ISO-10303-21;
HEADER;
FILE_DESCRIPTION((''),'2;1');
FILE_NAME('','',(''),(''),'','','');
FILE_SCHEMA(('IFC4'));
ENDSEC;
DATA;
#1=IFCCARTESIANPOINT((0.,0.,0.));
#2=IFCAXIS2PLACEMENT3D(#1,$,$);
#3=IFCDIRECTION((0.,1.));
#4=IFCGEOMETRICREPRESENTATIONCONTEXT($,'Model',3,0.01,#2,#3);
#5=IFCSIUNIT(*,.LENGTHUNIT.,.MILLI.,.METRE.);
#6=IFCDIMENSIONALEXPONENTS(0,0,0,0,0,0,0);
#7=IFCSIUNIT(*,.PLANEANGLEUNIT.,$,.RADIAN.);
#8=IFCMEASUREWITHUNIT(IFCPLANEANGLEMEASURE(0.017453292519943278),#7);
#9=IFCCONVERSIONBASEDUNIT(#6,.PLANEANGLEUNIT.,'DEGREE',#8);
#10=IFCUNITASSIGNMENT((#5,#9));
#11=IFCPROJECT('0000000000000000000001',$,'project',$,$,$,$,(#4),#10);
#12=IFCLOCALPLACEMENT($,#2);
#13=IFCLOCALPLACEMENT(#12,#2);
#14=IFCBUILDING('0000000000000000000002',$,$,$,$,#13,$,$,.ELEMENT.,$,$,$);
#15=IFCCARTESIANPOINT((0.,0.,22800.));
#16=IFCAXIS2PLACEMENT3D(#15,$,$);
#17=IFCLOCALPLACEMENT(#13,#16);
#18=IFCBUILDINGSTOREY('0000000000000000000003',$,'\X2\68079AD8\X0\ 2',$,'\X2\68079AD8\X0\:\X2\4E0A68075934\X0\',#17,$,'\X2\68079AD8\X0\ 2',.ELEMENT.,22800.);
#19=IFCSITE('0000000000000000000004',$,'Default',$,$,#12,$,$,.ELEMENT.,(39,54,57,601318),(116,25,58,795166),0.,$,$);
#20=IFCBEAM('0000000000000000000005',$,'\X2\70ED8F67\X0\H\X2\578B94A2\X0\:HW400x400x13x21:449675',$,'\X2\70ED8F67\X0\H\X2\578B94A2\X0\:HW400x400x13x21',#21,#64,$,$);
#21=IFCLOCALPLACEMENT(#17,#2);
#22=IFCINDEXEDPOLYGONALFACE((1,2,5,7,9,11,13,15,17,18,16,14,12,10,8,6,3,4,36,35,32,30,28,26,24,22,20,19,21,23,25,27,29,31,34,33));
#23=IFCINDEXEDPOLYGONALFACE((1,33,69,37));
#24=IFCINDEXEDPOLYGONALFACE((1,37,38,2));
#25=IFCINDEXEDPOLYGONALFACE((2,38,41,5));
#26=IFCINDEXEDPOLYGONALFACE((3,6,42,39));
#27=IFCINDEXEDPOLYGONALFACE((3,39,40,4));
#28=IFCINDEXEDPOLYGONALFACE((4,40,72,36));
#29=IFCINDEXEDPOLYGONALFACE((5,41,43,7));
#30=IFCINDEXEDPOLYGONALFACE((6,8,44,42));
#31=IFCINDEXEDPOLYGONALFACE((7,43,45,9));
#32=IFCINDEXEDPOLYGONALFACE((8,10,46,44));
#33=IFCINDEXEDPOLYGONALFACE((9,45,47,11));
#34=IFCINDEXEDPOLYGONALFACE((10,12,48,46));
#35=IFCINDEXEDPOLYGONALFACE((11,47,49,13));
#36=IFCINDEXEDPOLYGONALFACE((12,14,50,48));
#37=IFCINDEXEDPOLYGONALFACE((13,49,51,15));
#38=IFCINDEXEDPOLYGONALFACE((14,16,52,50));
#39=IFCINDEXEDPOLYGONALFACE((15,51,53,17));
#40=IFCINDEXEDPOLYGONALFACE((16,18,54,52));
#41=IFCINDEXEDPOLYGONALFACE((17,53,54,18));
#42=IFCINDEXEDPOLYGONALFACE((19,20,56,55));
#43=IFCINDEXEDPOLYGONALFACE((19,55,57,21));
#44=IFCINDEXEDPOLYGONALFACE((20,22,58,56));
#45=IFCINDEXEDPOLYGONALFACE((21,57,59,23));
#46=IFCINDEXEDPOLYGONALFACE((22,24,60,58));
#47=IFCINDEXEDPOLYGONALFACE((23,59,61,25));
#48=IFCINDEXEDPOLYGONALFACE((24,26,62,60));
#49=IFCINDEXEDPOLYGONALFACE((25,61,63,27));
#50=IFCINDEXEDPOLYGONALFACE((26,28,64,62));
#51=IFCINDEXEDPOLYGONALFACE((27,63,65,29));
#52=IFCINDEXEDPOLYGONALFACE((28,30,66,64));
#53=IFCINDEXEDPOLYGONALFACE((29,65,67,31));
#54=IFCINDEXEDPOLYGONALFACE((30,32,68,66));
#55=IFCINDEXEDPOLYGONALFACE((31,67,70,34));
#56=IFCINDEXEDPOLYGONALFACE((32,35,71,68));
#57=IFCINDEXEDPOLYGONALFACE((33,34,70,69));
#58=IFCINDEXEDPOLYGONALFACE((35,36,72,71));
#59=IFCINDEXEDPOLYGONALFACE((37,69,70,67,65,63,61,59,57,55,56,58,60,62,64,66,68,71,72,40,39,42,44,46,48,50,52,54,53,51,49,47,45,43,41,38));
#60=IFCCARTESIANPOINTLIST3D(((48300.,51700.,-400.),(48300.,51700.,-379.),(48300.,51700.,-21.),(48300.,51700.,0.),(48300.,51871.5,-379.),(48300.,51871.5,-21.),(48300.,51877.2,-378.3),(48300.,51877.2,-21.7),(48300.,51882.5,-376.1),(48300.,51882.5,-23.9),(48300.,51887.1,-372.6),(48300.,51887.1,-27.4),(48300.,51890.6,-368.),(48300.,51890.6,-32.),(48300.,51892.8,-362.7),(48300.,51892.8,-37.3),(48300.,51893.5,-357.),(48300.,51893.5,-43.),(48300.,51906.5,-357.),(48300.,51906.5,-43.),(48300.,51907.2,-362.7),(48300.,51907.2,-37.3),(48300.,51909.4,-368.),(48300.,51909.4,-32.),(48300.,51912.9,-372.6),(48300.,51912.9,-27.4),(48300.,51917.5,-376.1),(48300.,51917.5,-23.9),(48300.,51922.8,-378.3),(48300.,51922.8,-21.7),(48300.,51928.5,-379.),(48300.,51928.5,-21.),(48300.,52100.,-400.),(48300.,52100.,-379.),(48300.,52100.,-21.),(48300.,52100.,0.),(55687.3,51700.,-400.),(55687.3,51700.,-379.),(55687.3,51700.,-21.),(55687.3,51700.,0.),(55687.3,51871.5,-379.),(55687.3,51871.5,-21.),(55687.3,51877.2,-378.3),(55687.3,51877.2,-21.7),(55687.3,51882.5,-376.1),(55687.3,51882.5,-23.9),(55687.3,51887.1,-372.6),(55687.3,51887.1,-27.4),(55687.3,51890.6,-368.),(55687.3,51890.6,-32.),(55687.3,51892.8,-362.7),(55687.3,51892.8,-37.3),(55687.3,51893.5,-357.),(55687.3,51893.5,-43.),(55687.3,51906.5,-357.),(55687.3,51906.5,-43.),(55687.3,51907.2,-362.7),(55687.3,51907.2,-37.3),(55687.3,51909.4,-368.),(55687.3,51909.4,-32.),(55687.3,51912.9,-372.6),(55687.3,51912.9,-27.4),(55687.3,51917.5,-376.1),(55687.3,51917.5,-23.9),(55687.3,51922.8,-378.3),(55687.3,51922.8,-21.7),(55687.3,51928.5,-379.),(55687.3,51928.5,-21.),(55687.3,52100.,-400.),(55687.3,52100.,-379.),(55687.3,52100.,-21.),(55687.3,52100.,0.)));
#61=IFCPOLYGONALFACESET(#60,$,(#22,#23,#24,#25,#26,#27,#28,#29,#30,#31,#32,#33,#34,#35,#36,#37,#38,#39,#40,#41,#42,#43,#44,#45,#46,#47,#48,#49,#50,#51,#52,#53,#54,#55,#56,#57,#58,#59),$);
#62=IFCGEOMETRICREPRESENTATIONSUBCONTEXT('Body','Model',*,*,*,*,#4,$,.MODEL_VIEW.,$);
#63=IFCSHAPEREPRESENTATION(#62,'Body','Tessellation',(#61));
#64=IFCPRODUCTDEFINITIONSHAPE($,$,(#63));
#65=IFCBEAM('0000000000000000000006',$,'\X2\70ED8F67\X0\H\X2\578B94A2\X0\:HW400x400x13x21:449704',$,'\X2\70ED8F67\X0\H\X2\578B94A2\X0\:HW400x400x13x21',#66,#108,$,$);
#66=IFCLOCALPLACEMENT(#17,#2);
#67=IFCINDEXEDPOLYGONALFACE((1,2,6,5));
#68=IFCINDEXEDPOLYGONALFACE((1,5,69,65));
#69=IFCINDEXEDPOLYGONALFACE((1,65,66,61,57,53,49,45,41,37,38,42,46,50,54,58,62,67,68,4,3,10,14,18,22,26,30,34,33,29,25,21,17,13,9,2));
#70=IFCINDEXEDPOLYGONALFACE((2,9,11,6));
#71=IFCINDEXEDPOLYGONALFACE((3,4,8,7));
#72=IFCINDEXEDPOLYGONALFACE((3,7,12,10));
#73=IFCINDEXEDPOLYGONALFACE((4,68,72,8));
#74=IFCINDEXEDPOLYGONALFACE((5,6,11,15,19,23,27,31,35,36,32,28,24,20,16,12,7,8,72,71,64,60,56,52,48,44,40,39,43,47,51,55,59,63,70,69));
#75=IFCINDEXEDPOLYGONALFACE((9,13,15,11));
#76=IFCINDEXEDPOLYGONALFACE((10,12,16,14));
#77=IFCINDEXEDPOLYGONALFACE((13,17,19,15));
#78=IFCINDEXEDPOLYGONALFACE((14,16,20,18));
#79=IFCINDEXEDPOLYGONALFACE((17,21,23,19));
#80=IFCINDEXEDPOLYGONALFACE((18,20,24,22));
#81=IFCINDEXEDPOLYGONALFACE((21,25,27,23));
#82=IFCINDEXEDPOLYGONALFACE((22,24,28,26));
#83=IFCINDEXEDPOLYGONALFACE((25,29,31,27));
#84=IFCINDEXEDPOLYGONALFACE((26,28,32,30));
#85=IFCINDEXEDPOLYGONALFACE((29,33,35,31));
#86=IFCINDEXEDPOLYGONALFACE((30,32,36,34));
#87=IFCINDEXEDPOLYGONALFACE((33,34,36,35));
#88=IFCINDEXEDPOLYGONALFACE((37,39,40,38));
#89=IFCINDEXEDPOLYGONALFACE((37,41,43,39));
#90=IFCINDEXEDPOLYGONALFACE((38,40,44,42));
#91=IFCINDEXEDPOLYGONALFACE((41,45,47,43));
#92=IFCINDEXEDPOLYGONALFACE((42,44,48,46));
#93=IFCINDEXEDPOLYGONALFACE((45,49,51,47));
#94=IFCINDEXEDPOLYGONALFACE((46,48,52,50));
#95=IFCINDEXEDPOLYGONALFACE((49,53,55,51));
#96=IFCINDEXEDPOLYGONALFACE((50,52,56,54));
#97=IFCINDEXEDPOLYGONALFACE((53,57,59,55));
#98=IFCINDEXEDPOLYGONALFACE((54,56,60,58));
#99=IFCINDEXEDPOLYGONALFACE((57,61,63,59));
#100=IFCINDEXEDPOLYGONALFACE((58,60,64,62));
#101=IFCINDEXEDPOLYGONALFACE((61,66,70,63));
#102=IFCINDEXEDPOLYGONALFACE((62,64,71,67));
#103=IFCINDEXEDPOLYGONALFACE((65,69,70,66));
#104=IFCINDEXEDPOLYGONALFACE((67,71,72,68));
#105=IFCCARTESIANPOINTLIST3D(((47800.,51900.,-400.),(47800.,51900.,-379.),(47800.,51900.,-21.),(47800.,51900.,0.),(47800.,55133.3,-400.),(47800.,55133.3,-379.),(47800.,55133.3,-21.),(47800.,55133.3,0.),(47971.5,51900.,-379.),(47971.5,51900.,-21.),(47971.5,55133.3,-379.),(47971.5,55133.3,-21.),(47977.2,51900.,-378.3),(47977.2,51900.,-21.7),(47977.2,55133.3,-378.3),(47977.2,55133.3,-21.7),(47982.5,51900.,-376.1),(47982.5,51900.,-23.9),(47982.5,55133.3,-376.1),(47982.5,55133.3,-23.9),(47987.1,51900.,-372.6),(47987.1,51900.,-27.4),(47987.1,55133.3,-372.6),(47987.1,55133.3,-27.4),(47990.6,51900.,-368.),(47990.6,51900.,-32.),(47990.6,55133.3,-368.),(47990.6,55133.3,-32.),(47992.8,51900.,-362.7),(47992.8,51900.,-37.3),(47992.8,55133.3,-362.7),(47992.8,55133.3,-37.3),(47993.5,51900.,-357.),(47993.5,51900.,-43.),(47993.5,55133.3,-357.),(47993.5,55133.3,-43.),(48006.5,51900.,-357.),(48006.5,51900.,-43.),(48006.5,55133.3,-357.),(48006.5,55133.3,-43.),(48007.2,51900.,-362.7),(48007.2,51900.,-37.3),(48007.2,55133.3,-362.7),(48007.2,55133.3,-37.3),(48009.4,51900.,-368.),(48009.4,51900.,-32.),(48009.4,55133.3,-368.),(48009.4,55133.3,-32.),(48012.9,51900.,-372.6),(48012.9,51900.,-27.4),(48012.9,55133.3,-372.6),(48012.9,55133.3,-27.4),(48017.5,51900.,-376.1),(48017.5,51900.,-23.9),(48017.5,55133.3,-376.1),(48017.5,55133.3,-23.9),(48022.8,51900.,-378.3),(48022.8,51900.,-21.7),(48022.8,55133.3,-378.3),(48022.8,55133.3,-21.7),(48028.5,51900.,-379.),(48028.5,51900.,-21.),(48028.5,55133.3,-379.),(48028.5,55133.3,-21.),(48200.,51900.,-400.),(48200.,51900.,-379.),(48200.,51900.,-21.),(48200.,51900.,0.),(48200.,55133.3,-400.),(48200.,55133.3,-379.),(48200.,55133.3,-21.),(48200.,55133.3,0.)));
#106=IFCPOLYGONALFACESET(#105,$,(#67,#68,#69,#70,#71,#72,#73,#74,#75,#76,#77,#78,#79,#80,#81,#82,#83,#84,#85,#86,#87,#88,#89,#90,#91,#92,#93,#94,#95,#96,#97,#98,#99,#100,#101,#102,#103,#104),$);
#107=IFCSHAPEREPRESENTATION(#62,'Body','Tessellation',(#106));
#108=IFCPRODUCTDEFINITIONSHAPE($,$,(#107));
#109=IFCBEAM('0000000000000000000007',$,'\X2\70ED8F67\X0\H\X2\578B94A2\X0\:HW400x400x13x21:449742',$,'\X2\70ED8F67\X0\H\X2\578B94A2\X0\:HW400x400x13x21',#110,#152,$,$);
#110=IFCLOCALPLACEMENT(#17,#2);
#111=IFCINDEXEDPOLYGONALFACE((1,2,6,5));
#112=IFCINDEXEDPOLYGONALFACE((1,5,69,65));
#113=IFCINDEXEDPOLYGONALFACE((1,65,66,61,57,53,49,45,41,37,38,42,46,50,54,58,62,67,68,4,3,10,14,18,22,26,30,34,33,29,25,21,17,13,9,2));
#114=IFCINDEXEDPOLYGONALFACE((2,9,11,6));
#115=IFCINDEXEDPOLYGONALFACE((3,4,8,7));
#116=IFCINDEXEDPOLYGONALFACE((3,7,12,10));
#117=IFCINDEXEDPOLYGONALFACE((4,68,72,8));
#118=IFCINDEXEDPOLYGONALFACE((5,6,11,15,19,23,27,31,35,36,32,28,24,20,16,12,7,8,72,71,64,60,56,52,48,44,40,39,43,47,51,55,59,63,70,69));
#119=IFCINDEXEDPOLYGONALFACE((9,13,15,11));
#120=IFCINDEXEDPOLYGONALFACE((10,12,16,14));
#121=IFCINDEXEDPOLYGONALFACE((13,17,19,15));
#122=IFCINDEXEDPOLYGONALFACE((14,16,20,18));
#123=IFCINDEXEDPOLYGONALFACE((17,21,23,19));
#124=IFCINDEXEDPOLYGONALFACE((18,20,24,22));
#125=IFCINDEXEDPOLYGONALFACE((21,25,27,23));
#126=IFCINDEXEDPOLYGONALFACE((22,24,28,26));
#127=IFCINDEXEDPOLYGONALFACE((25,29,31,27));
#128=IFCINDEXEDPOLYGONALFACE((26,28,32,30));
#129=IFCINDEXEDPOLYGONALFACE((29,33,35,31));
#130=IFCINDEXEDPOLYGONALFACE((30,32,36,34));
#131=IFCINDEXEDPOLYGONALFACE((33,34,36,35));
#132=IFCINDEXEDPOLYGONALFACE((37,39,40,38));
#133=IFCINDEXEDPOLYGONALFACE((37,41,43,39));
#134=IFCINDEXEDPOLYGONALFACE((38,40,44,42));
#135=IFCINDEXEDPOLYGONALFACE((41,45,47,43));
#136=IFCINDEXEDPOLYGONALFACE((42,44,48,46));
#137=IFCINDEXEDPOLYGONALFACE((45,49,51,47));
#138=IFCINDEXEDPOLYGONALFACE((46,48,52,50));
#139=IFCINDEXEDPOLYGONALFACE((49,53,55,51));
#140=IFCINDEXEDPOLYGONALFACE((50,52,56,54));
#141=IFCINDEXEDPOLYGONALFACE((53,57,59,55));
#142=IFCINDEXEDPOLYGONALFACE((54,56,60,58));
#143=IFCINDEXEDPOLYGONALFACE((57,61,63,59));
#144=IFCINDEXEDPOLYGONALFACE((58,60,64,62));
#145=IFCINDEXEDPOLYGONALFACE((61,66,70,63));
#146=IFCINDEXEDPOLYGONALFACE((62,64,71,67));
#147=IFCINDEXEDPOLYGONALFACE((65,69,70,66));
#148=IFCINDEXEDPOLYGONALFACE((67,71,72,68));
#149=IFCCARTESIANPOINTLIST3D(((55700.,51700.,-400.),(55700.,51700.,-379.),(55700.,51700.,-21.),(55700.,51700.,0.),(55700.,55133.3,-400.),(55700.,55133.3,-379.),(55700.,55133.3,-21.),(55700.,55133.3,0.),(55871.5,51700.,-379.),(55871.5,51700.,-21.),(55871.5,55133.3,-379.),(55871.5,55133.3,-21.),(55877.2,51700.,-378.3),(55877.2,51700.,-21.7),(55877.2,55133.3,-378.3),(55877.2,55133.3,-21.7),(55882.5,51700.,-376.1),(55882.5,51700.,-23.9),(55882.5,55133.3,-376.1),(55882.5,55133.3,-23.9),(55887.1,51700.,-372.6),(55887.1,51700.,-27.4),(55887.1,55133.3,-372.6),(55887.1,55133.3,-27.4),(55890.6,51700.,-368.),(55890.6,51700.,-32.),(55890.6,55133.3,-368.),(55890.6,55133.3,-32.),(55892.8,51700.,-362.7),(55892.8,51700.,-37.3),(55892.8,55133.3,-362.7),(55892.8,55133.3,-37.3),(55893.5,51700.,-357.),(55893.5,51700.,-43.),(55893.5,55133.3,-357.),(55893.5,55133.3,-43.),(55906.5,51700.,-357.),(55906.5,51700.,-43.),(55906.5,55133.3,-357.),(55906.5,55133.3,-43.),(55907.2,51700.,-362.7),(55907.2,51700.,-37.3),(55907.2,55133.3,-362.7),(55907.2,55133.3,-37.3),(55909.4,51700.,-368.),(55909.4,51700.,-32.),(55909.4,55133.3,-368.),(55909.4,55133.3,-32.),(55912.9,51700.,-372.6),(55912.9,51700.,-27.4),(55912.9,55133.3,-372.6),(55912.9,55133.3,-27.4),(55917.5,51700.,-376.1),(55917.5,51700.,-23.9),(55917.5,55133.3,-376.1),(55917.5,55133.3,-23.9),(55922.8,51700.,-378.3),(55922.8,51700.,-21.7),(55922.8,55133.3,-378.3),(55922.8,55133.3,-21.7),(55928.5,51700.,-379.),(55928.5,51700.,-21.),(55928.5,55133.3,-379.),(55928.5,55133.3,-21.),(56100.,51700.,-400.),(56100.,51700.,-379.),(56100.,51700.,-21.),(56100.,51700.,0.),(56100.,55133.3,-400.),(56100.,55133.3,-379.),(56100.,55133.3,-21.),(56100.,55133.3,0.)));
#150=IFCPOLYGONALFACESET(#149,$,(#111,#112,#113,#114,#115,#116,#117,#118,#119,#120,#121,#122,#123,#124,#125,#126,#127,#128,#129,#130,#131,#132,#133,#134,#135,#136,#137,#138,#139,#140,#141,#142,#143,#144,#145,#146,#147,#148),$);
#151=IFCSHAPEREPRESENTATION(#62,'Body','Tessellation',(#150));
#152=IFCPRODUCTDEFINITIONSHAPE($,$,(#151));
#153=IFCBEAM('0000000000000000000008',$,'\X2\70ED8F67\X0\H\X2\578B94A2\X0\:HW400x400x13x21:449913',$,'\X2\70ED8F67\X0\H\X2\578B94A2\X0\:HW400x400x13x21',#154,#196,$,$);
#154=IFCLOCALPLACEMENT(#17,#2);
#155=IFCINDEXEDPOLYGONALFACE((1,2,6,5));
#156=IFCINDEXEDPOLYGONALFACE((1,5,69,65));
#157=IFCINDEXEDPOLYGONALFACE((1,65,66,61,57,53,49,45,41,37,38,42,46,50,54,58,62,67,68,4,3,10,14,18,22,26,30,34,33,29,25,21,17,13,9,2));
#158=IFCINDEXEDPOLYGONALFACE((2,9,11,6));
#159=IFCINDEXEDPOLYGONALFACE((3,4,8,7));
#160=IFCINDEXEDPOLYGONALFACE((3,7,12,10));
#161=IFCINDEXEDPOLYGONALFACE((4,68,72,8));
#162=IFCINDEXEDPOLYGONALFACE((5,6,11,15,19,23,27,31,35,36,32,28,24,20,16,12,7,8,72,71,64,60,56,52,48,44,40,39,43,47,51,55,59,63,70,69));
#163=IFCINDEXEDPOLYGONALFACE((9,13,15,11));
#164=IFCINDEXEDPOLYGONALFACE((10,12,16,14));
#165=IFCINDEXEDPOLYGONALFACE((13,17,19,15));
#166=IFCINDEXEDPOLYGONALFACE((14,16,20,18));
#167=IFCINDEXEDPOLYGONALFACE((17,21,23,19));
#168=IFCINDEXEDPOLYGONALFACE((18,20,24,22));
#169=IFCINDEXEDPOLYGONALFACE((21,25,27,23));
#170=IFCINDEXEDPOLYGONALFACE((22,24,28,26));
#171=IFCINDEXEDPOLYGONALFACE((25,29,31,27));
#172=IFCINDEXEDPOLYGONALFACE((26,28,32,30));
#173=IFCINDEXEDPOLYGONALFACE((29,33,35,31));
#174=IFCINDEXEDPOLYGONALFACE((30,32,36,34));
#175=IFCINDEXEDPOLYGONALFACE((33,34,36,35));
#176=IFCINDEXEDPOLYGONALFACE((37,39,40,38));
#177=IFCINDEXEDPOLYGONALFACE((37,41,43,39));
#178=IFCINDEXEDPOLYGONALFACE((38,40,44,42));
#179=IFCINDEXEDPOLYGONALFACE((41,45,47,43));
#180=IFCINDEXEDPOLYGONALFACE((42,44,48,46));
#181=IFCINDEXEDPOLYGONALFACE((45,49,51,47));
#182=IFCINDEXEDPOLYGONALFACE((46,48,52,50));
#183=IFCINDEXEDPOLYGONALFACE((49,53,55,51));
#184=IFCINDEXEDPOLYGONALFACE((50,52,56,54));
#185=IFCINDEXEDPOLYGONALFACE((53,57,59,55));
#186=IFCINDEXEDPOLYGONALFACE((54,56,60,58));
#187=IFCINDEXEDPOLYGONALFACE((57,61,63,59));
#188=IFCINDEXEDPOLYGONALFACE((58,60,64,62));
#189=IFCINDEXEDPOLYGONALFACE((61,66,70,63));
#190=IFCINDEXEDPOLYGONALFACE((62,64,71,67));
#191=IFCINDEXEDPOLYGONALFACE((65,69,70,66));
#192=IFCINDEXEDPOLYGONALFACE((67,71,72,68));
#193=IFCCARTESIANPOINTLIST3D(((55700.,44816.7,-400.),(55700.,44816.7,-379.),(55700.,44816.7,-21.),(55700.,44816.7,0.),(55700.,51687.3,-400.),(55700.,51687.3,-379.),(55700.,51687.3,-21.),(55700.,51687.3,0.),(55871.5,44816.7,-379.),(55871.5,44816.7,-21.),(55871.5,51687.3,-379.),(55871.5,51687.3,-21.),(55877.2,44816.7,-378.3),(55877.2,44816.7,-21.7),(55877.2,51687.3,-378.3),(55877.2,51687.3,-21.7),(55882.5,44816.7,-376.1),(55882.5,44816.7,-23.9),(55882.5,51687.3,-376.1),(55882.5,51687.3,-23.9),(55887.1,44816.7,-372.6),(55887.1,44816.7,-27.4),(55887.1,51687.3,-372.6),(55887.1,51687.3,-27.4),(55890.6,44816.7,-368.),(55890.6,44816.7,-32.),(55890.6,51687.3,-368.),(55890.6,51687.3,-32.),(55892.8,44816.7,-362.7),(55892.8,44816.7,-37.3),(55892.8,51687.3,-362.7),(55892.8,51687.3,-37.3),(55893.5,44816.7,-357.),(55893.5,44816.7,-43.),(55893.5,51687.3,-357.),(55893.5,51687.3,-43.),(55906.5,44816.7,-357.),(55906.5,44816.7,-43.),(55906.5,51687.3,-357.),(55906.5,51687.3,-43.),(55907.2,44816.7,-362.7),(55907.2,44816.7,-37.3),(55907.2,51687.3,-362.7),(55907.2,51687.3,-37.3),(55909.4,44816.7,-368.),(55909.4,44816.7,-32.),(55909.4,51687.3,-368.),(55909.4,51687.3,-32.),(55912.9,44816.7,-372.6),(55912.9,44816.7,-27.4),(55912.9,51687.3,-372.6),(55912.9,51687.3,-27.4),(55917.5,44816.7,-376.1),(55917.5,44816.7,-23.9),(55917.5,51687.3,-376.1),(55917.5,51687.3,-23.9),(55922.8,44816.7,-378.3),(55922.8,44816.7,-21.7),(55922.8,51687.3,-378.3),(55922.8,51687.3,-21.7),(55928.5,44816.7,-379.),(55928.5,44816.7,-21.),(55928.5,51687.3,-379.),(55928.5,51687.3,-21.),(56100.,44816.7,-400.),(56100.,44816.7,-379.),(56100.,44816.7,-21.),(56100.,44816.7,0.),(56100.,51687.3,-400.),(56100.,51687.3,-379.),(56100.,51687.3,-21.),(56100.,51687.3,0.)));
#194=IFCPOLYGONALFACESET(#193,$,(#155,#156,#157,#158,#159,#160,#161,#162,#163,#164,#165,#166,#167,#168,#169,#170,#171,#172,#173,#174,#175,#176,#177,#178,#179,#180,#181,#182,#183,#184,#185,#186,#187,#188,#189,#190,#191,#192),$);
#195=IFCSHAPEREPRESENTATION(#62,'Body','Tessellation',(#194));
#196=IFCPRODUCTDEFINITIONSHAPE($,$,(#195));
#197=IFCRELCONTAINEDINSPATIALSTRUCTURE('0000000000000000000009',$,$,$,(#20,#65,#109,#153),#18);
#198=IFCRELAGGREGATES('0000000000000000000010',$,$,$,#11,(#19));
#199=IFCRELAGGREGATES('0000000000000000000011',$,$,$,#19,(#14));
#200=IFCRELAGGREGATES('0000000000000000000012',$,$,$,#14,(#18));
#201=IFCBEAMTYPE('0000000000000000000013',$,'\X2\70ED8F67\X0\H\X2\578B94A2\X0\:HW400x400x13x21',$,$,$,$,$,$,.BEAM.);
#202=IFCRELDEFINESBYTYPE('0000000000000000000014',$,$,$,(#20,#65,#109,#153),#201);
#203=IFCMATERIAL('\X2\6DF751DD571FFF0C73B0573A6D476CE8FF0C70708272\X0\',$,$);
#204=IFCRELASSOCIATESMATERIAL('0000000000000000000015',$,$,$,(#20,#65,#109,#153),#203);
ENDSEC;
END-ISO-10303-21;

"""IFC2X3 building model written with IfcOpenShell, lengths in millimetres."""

from ifc_helpers import new_model, entity, si_unit, converted_unit, direction, frame, frame_2d, origin, place, context, subcontext, project, spatial, i_section, extrude, material, type_object, element, save


model = new_model("IFC2X3")

# Units and contexts
model_context = context("Model", 3, precision=0.01, world=origin(), true_north=direction((0.0, 1.0)))
body_context = subcontext(model_context, "Body", "Model", "MODEL_VIEW")
ifc_project = project(units=[si_unit("LENGTHUNIT", "METRE", prefix="MILLI"), converted_unit("PLANEANGLEUNIT", "DEGREE", entity("IfcPlaneAngleMeasure", 0.017453292519943278), si_unit("PLANEANGLEUNIT", "RADIAN"), dimensions=[0, 0, 0, 0, 0, 0, 0])], contexts=[model_context])

# Site, building, storey
site_placement = place(None, origin())
site = spatial("IfcSite", under=ifc_project, at=site_placement, Name="Default", CompositionType="ELEMENT", RefLatitude=(39, 54, 57, 601318), RefLongitude=(116, 25, 58, 795166), RefElevation=0.0)
building_placement = place(site_placement, origin())
building = spatial("IfcBuilding", under=site, at=building_placement, CompositionType="ELEMENT")
storey_placement = place(building_placement, frame((0.0, 0.0, 22800.0)))
storey = spatial("IfcBuildingStorey", under=building, at=storey_placement, Name="标高 2", ObjectType="标高:上标头", LongName="标高 2", CompositionType="ELEMENT", Elevation=22800.0)

# Beams
ifc_material = material(Name="混凝土，现场浇注，灰色")
beam_type = type_object("IfcBeamType", Name="热轧H型钢:HW400x400x13x21", PredefinedType="BEAM")
beam_1_placement = place(storey_placement, frame((48300.0, 51900.0, 0.0)))
element("IfcBeam", 1, at=beam_1_placement, inside=storey, type_object=beam_type, material=ifc_material, Name="热轧H型钢:HW400x400x13x21:449675", ObjectType="热轧H型钢:HW400x400x13x21", context=body_context, shape_type="SweptSolid", body=[
    extrude(i_section(OverallWidth=400.0, OverallDepth=400.0, WebThickness=13.0, FlangeThickness=21.0, FilletRadius=22.0, at=frame_2d((0.0, 0.0), x_axis=(0.0, 1.0))), frame((0.0, 0.0, -200.0), z_axis=(1.0, 0.0, 0.0), x_axis=(0.0, 0.0, -1.0)), (0.0, 0.0, 1.0), 7387.3),
])
beam_2_placement = place(storey_placement, frame((48000.0, 55400.0, 0.0), z_axis=(0.0, 0.0, 1.0), x_axis=(0.0, -1.0, 0.0)))
element("IfcBeam", 2, at=beam_2_placement, inside=storey, type_object=beam_type, material=ifc_material, Name="热轧H型钢:HW400x400x13x21:449704", ObjectType="热轧H型钢:HW400x400x13x21", context=body_context, shape_type="SweptSolid", body=[
    extrude(i_section(OverallWidth=400.0, OverallDepth=400.0, WebThickness=13.0, FlangeThickness=21.0, FilletRadius=22.0, at=frame_2d((0.0, 0.0), x_axis=(0.0, 1.0))), frame((266.7, 0.0, -200.0), z_axis=(1.0, 0.0, 0.0), x_axis=(0.0, 0.0, -1.0)), (0.0, 0.0, 1.0), 3233.3),
])
beam_3_placement = place(storey_placement, frame((55900.0, 55400.0, 0.0), z_axis=(0.0, 0.0, 1.0), x_axis=(0.0, -1.0, 0.0)))
element("IfcBeam", 3, at=beam_3_placement, inside=storey, type_object=beam_type, material=ifc_material, Name="热轧H型钢:HW400x400x13x21:449742", ObjectType="热轧H型钢:HW400x400x13x21", context=body_context, shape_type="SweptSolid", body=[
    extrude(i_section(OverallWidth=400.0, OverallDepth=400.0, WebThickness=13.0, FlangeThickness=21.0, FilletRadius=22.0, at=frame_2d((0.0, 0.0), x_axis=(0.0, 1.0))), frame((266.7, 0.0, -200.0), z_axis=(1.0, 0.0, 0.0), x_axis=(0.0, 0.0, -1.0)), (0.0, 0.0, 1.0), 3433.3),
])
beam_4_placement = place(storey_placement, frame((55900.0, 51900.0, 0.0), z_axis=(0.0, 0.0, 1.0), x_axis=(0.0, -1.0, 0.0)))
element("IfcBeam", 4, at=beam_4_placement, inside=storey, type_object=beam_type, material=ifc_material, Name="热轧H型钢:HW400x400x13x21:449913", ObjectType="热轧H型钢:HW400x400x13x21", context=body_context, shape_type="SweptSolid", body=[
    extrude(i_section(OverallWidth=400.0, OverallDepth=400.0, WebThickness=13.0, FlangeThickness=21.0, FilletRadius=22.0, at=frame_2d((0.0, 0.0), x_axis=(0.0, 1.0))), frame((212.7, 0.0, -200.0), z_axis=(1.0, 0.0, 0.0), x_axis=(0.0, 0.0, -1.0)), (0.0, 0.0, 1.0), 6870.6),
])

save(model, "model.ifc")
